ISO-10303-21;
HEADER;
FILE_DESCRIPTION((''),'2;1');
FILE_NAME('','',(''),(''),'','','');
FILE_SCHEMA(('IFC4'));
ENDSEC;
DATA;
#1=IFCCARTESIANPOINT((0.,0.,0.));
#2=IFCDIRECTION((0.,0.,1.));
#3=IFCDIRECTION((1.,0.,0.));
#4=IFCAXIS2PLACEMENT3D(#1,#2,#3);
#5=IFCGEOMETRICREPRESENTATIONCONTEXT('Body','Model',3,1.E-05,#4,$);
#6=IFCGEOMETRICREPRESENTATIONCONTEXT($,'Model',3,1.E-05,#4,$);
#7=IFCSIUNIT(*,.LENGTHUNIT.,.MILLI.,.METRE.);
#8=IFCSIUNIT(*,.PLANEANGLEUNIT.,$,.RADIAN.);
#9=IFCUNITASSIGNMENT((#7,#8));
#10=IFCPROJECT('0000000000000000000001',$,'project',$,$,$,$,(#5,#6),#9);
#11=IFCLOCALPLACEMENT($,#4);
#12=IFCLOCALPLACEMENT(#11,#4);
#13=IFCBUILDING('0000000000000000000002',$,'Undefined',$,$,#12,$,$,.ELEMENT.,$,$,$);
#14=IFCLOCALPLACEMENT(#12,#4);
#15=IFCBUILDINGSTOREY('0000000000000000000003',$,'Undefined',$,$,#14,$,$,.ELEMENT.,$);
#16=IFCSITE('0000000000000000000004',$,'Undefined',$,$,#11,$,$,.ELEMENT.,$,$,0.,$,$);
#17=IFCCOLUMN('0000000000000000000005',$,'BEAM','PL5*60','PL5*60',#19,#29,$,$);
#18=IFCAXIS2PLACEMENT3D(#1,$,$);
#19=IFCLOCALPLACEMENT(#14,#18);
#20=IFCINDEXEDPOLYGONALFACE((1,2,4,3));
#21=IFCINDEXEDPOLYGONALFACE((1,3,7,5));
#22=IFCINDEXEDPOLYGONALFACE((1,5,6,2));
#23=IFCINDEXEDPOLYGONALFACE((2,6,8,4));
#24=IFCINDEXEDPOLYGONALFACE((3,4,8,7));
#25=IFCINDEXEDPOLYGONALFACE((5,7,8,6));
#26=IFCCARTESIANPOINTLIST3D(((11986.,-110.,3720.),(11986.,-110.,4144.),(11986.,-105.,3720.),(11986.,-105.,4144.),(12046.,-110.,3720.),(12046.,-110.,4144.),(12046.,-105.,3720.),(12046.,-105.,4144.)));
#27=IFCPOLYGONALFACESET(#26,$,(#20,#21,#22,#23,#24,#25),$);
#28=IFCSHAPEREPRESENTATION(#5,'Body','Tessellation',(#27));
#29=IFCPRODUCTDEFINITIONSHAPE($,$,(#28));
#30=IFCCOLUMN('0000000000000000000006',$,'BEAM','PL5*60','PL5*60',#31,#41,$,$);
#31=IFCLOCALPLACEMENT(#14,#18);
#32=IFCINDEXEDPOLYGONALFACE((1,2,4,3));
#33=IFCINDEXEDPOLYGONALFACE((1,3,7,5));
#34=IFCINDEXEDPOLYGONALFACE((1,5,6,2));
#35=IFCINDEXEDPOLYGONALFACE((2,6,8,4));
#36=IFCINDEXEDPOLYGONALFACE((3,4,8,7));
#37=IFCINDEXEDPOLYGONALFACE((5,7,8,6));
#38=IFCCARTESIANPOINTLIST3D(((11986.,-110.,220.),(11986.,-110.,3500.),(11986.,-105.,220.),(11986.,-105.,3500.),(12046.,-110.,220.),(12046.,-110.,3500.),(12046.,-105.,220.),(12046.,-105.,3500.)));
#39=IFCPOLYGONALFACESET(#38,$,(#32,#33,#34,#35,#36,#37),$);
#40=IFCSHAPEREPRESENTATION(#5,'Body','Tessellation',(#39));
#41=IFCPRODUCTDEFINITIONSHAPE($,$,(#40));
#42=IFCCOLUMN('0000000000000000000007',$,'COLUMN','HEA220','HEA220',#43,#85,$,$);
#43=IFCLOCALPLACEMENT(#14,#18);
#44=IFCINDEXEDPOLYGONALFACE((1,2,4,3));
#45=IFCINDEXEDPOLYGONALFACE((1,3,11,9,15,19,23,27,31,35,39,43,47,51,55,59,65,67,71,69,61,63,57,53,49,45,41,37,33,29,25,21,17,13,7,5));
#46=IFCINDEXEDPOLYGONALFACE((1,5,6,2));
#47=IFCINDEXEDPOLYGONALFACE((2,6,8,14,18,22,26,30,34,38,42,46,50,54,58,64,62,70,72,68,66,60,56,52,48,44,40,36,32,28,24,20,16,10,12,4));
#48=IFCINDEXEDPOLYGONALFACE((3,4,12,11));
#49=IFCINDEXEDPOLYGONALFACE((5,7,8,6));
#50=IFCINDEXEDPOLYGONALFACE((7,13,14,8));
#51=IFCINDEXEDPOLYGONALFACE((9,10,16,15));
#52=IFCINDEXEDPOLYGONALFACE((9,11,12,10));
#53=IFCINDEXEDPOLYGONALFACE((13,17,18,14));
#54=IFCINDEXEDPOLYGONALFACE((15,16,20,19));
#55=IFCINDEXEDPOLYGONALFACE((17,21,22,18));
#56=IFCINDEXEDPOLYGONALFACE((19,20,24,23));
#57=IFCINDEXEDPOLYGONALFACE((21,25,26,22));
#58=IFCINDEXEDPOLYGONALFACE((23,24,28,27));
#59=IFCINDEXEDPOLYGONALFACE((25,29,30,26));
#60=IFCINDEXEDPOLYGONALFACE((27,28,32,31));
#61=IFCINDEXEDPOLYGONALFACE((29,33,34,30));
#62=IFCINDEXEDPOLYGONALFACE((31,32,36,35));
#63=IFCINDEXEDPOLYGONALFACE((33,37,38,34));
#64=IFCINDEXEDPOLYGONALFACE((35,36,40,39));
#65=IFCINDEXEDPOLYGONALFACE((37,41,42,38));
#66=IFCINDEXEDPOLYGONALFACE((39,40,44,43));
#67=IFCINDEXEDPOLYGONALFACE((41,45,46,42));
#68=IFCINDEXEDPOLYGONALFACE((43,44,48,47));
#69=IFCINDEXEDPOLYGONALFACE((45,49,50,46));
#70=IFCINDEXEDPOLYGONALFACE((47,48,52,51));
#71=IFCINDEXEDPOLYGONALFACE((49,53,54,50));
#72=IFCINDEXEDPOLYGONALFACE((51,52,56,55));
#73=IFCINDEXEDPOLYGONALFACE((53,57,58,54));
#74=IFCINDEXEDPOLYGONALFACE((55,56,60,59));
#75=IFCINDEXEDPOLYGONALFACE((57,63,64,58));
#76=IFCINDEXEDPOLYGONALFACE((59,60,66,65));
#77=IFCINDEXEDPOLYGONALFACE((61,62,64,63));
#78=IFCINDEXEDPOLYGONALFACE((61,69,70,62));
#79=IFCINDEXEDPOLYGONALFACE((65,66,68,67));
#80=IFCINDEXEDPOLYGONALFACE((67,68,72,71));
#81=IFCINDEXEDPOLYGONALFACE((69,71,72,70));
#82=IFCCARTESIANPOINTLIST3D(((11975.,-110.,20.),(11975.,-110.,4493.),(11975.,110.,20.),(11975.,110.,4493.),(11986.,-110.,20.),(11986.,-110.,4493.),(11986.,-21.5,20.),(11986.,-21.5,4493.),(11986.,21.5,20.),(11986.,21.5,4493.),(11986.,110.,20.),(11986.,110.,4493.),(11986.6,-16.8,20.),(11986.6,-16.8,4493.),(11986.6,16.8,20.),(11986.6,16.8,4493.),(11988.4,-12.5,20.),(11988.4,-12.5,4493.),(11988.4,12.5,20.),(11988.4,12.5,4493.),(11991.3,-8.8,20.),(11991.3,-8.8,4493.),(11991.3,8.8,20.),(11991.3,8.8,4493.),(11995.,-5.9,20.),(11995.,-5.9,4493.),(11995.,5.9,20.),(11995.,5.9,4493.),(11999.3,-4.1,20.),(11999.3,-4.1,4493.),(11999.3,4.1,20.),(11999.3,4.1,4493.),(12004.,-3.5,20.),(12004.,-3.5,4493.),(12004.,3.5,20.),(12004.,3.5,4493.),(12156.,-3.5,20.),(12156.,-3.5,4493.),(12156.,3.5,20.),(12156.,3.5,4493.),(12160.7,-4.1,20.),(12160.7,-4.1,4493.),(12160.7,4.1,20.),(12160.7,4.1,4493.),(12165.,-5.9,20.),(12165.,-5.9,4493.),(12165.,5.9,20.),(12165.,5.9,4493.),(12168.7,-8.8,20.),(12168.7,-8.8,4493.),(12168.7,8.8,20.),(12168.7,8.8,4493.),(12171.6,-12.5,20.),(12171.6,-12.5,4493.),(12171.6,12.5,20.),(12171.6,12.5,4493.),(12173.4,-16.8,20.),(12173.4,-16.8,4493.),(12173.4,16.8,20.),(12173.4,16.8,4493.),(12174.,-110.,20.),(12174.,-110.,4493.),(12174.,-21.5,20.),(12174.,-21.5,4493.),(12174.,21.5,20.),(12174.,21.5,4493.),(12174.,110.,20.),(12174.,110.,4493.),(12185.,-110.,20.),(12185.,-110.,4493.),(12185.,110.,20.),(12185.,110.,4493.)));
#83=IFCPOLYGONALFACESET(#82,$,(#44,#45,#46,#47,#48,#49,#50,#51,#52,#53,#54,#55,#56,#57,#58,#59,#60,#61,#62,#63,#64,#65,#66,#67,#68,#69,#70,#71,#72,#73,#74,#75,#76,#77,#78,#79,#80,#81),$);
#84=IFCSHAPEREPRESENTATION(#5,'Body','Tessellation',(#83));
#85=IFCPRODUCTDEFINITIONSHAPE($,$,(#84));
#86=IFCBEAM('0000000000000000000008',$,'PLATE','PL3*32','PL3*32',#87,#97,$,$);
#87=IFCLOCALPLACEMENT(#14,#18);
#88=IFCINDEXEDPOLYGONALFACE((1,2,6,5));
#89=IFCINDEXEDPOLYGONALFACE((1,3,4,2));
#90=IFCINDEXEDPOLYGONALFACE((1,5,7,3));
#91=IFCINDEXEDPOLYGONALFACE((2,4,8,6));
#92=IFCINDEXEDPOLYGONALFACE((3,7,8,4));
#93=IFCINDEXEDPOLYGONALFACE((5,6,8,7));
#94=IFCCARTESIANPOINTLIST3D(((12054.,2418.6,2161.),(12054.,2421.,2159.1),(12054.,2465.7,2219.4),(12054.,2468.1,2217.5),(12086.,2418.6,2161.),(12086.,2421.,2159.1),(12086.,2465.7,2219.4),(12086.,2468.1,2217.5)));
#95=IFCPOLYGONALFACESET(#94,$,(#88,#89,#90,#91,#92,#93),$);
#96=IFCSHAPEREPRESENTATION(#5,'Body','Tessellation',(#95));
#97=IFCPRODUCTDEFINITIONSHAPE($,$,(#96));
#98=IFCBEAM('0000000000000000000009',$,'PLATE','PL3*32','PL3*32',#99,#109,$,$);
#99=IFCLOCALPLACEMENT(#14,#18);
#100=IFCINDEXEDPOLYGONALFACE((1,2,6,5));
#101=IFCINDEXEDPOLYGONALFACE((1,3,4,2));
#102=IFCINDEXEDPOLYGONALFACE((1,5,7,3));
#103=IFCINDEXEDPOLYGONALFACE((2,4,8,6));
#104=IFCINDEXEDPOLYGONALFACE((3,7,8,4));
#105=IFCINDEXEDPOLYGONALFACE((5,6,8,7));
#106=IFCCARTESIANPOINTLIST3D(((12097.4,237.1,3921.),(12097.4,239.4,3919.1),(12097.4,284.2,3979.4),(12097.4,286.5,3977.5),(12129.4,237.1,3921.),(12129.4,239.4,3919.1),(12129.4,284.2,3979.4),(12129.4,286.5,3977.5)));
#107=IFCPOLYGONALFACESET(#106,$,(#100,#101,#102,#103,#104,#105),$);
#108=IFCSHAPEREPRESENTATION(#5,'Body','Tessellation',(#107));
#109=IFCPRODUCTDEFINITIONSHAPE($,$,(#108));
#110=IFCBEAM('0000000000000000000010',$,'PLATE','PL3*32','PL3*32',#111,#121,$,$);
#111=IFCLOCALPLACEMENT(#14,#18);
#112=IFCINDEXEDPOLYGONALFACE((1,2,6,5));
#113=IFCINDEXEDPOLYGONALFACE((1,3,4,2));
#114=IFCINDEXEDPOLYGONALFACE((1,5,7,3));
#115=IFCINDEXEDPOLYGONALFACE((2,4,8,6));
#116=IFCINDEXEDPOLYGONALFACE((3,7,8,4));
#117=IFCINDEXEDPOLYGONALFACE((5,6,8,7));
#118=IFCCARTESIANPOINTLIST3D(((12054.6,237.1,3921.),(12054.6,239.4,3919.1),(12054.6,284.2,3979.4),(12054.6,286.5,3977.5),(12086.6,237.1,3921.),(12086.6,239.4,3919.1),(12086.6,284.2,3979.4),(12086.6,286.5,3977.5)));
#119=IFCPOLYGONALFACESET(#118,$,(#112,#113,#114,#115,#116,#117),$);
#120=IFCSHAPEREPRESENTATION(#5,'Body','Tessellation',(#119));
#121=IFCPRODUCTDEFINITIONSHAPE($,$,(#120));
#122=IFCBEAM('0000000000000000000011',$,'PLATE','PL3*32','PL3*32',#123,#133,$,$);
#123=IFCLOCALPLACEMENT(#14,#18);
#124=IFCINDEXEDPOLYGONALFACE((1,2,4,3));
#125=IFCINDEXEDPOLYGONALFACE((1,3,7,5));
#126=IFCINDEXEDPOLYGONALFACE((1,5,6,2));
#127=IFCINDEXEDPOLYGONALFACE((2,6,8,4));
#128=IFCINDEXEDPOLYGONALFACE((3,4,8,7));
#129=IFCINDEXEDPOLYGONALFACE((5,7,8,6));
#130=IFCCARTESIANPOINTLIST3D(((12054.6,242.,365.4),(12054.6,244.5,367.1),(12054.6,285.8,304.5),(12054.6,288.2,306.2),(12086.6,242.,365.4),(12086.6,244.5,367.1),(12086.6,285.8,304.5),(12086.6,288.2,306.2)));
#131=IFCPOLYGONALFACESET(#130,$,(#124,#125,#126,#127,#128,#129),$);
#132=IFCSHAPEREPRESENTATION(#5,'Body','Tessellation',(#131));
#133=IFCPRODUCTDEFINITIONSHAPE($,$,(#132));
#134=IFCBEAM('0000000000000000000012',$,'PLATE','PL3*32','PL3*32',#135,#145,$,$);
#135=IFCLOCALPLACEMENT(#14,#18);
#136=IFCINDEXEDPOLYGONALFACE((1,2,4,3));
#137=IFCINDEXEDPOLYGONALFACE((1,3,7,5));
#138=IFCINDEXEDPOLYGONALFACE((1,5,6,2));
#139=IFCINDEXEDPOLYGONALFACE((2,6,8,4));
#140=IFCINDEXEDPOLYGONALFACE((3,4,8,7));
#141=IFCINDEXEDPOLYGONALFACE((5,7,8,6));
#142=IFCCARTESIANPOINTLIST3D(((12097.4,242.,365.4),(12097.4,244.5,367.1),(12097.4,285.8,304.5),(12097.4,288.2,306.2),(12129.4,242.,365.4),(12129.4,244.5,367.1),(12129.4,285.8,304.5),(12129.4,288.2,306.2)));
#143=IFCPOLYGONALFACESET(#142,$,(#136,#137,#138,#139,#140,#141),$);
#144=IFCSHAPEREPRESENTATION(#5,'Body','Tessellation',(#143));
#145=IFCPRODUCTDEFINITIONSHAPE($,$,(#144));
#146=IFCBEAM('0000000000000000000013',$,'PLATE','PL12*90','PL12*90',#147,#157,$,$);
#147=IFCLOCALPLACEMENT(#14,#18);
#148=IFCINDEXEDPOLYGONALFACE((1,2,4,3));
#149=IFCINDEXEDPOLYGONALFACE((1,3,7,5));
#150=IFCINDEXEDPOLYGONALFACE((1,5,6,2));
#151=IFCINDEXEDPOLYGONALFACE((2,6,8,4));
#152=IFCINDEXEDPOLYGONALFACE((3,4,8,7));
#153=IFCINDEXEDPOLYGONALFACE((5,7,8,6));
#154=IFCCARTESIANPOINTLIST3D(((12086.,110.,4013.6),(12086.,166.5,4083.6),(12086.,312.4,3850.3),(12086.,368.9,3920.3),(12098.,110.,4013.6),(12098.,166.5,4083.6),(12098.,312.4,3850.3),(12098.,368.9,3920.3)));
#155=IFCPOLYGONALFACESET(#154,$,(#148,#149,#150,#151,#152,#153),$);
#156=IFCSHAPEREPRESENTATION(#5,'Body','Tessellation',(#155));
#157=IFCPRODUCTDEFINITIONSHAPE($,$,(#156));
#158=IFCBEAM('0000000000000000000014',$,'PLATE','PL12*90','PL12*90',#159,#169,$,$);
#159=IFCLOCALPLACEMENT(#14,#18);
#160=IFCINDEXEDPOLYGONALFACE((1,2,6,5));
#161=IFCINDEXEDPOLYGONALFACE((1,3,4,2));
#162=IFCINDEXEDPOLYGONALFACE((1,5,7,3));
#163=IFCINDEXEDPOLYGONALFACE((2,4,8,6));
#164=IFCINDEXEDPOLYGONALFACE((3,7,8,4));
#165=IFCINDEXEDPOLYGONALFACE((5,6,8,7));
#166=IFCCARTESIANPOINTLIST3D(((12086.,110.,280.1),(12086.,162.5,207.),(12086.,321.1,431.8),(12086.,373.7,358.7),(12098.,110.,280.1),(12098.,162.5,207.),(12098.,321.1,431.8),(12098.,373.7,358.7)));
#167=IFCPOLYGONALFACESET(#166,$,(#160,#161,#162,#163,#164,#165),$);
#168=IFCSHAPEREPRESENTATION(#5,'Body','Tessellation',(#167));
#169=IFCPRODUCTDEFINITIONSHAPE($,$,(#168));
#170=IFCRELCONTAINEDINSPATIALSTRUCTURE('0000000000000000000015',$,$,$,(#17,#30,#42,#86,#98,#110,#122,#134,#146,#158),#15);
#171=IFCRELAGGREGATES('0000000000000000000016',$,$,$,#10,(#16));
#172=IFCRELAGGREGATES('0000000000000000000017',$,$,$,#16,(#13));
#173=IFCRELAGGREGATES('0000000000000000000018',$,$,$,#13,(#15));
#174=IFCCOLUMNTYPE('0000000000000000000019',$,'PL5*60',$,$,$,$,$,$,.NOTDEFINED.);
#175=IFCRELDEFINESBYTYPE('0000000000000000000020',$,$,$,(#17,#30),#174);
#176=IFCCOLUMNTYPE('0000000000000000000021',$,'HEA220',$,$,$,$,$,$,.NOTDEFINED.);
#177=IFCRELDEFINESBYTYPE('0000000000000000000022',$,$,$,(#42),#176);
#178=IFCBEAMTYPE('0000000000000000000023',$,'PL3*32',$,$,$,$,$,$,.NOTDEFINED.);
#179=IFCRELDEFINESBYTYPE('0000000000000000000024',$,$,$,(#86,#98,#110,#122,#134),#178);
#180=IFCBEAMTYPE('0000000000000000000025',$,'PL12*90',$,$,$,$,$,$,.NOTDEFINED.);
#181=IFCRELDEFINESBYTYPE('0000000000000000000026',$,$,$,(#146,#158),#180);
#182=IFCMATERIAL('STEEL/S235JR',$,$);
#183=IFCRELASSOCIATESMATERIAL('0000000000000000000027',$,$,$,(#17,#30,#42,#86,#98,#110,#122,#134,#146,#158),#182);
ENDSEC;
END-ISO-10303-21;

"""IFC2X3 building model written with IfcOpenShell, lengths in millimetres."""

from ifc_helpers import new_model, si_unit, frame, origin_with_axes, origin_2d_with_axis, place, context, project, spatial, rectangle, i_section, extrude, material, type_object, element, save


model = new_model("IFC2X3")

# Units and contexts
model_context_1 = context("Model", 3, precision=1e-05, world=origin_with_axes(), identifier="Body")
model_context_2 = context("Model", 3, precision=1e-05, world=origin_with_axes())
ifc_project = project(units=[si_unit("LENGTHUNIT", "METRE", prefix="MILLI"), si_unit("PLANEANGLEUNIT", "RADIAN")], contexts=[model_context_1, model_context_2])

# Site, building, storey
site_placement = place(None, origin_with_axes())
site = spatial("IfcSite", under=ifc_project, at=site_placement, Name="Undefined", CompositionType="ELEMENT", RefElevation=0.0)
building_placement = place(site_placement, origin_with_axes())
building = spatial("IfcBuilding", under=site, at=building_placement, Name="Undefined", CompositionType="ELEMENT")
storey_placement = place(building_placement, origin_with_axes())
storey = spatial("IfcBuildingStorey", under=building, at=storey_placement, Name="Undefined", CompositionType="ELEMENT")

# Columns
ifc_material = material(Name="STEEL/S235JR")
column_type_1 = type_object("IfcColumnType", Name="PL5*60", PredefinedType="NOTDEFINED")
column_1_placement = place(storey_placement, frame((12016.0, -107.5, 3720.0), z_axis=(0.0, 0.0, 1.0), x_axis=(1.0, 0.0, 0.0)))
element("IfcColumn", 1, at=column_1_placement, inside=storey, type_object=column_type_1, material=ifc_material, Name="BEAM", Description="PL5*60", ObjectType="PL5*60", context=model_context_1, shape_type="SweptSolid", body=[
    extrude(rectangle(XDim=5.0, YDim=60.0, at=origin_2d_with_axis()), frame((0.0, 0.0, 424.0), z_axis=(0.0, 0.0, -1.0), x_axis=(0.0, -1.0, 0.0)), (0.0, 0.0, 1.0), 424.0),
])
column_2_placement = place(storey_placement, frame((12016.0, -107.5, 220.0), z_axis=(0.0, 0.0, 1.0), x_axis=(1.0, 0.0, 0.0)))
element("IfcColumn", 2, at=column_2_placement, inside=storey, type_object=column_type_1, material=ifc_material, Name="BEAM", Description="PL5*60", ObjectType="PL5*60", context=model_context_1, shape_type="SweptSolid", body=[
    extrude(rectangle(XDim=5.0, YDim=60.0, at=origin_2d_with_axis()), frame((0.0, 0.0, 3280.0), z_axis=(0.0, 0.0, -1.0), x_axis=(0.0, -1.0, 0.0)), (0.0, 0.0, 1.0), 3280.0),
])
column_type_2 = type_object("IfcColumnType", Name="HEA220", PredefinedType="NOTDEFINED")
column_3_placement = place(storey_placement, frame((12080.0, 0.0, 0.0), z_axis=(0.0, 0.0, 1.0), x_axis=(1.0, 0.0, 0.0)))
element("IfcColumn", 3, at=column_3_placement, inside=storey, type_object=column_type_2, material=ifc_material, Name="COLUMN", Description="HEA220", ObjectType="HEA220", context=model_context_1, shape_type="SweptSolid", body=[
    extrude(i_section(OverallWidth=220.0, OverallDepth=210.0, WebThickness=7.0, FlangeThickness=11.0, FilletRadius=18.0, at=origin_2d_with_axis()), frame((0.0, 0.0, 4493.0), z_axis=(0.0, 0.0, -1.0), x_axis=(0.0, -1.0, 0.0)), (0.0, 0.0, 1.0), 4473.0),
])

# Beams
beam_type_1 = type_object("IfcBeamType", Name="PL3*32", PredefinedType="NOTDEFINED")
beam_1_placement = place(storey_placement, frame((12070.0, 2419.8, 2160.1), z_axis=(1.0, 0.0, 0.0), x_axis=(0.0, 0.627892, 0.7783)))
element("IfcBeam", 4, at=beam_1_placement, inside=storey, type_object=beam_type_1, material=ifc_material, Name="PLATE", Description="PL3*32", ObjectType="PL3*32", context=model_context_1, shape_type="SweptSolid", body=[
    extrude(rectangle(XDim=3.0, YDim=32.0, at=origin_2d_with_axis()), frame((75.0, 0.0, 0.0), z_axis=(-1.0, 0.0, 0.0), x_axis=(0.0, -1.0, 0.0)), (0.0, 0.0, 1.0), 75.0),
])
for number, where, z_axis, x_axis, name in (
    (5, (12113.4, 238.2, 3920.1), (-1.0, 0.0, 0.0), (0.0, 0.627892, 0.7783), "PLATE"),
    (6, (12070.6, 238.2, 3920.1), (1.0, 0.0, 0.0), (0.0, 0.627892, 0.7783), "PLATE"),
):
    element("IfcBeam", number, at=place(storey_placement, frame(where, z_axis=z_axis, x_axis=x_axis)), inside=storey, type_object=beam_type_1, material=ifc_material, Name=name, Description="PL3*32", ObjectType="PL3*32", context=model_context_1, shape_type="SweptSolid", body=[
        extrude(rectangle(XDim=3.0, YDim=32.0, at=origin_2d_with_axis()), frame((75.0, 0.0, 0.0), z_axis=(-1.0, 0.0, 0.0), x_axis=(0.0, -1.0, 0.0)), (0.0, 0.0, 1.0), 75.0),
    ])
for number, where, z_axis, x_axis, name in (
    (7, (12070.6, 243.2, 366.3), (1.0, 0.0, 0.0), (0.0, 0.583515, -0.812102), "PLATE"),
    (8, (12113.4, 243.2, 366.3), (-1.0, 0.0, 0.0), (0.0, 0.583515, -0.812102), "PLATE"),
):
    element("IfcBeam", number, at=place(storey_placement, frame(where, z_axis=z_axis, x_axis=x_axis)), inside=storey, type_object=beam_type_1, material=ifc_material, Name=name, Description="PL3*32", ObjectType="PL3*32", context=model_context_1, shape_type="SweptSolid", body=[
        extrude(rectangle(XDim=3.0, YDim=32.0, at=origin_2d_with_axis()), frame((75.0, 0.0, 0.0), z_axis=(-1.0, 0.0, 0.0), x_axis=(0.0, -1.0, 0.0)), (0.0, 0.0, 1.0), 75.0),
    ])
beam_type_2 = type_object("IfcBeamType", Name="PL12*90", PredefinedType="NOTDEFINED")
beam_2_placement = place(storey_placement, frame((12092.0, 138.3, 4048.6), z_axis=(0.0, 0.627892, 0.7783), x_axis=(0.0, 0.7783, -0.627892)))
element("IfcBeam", 9, at=beam_2_placement, inside=storey, type_object=beam_type_2, material=ifc_material, Name="PLATE", Description="PL12*90", ObjectType="PL12*90", context=model_context_1, shape_type="SweptSolid", body=[
    extrude(rectangle(XDim=12.0, YDim=90.0, at=origin_2d_with_axis()), frame((260.0, 0.0, 0.0), z_axis=(-1.0, 0.0, 0.0), x_axis=(0.0, -1.0, 0.0)), (0.0, 0.0, 1.0), 260.0),
])
beam_3_placement = place(storey_placement, frame((12092.0, 136.3, 243.5), z_axis=(0.0, 0.583515, -0.812102), x_axis=(0.0, 0.812102, 0.583515)))
element("IfcBeam", 10, at=beam_3_placement, inside=storey, type_object=beam_type_2, material=ifc_material, Name="PLATE", Description="PL12*90", ObjectType="PL12*90", context=model_context_1, shape_type="SweptSolid", body=[
    extrude(rectangle(XDim=12.0, YDim=90.0, at=origin_2d_with_axis()), frame((260.0, 0.0, 0.0), z_axis=(-1.0, 0.0, 0.0), x_axis=(0.0, -1.0, 0.0)), (0.0, 0.0, 1.0), 260.0),
])

save(model, "model.ifc")
